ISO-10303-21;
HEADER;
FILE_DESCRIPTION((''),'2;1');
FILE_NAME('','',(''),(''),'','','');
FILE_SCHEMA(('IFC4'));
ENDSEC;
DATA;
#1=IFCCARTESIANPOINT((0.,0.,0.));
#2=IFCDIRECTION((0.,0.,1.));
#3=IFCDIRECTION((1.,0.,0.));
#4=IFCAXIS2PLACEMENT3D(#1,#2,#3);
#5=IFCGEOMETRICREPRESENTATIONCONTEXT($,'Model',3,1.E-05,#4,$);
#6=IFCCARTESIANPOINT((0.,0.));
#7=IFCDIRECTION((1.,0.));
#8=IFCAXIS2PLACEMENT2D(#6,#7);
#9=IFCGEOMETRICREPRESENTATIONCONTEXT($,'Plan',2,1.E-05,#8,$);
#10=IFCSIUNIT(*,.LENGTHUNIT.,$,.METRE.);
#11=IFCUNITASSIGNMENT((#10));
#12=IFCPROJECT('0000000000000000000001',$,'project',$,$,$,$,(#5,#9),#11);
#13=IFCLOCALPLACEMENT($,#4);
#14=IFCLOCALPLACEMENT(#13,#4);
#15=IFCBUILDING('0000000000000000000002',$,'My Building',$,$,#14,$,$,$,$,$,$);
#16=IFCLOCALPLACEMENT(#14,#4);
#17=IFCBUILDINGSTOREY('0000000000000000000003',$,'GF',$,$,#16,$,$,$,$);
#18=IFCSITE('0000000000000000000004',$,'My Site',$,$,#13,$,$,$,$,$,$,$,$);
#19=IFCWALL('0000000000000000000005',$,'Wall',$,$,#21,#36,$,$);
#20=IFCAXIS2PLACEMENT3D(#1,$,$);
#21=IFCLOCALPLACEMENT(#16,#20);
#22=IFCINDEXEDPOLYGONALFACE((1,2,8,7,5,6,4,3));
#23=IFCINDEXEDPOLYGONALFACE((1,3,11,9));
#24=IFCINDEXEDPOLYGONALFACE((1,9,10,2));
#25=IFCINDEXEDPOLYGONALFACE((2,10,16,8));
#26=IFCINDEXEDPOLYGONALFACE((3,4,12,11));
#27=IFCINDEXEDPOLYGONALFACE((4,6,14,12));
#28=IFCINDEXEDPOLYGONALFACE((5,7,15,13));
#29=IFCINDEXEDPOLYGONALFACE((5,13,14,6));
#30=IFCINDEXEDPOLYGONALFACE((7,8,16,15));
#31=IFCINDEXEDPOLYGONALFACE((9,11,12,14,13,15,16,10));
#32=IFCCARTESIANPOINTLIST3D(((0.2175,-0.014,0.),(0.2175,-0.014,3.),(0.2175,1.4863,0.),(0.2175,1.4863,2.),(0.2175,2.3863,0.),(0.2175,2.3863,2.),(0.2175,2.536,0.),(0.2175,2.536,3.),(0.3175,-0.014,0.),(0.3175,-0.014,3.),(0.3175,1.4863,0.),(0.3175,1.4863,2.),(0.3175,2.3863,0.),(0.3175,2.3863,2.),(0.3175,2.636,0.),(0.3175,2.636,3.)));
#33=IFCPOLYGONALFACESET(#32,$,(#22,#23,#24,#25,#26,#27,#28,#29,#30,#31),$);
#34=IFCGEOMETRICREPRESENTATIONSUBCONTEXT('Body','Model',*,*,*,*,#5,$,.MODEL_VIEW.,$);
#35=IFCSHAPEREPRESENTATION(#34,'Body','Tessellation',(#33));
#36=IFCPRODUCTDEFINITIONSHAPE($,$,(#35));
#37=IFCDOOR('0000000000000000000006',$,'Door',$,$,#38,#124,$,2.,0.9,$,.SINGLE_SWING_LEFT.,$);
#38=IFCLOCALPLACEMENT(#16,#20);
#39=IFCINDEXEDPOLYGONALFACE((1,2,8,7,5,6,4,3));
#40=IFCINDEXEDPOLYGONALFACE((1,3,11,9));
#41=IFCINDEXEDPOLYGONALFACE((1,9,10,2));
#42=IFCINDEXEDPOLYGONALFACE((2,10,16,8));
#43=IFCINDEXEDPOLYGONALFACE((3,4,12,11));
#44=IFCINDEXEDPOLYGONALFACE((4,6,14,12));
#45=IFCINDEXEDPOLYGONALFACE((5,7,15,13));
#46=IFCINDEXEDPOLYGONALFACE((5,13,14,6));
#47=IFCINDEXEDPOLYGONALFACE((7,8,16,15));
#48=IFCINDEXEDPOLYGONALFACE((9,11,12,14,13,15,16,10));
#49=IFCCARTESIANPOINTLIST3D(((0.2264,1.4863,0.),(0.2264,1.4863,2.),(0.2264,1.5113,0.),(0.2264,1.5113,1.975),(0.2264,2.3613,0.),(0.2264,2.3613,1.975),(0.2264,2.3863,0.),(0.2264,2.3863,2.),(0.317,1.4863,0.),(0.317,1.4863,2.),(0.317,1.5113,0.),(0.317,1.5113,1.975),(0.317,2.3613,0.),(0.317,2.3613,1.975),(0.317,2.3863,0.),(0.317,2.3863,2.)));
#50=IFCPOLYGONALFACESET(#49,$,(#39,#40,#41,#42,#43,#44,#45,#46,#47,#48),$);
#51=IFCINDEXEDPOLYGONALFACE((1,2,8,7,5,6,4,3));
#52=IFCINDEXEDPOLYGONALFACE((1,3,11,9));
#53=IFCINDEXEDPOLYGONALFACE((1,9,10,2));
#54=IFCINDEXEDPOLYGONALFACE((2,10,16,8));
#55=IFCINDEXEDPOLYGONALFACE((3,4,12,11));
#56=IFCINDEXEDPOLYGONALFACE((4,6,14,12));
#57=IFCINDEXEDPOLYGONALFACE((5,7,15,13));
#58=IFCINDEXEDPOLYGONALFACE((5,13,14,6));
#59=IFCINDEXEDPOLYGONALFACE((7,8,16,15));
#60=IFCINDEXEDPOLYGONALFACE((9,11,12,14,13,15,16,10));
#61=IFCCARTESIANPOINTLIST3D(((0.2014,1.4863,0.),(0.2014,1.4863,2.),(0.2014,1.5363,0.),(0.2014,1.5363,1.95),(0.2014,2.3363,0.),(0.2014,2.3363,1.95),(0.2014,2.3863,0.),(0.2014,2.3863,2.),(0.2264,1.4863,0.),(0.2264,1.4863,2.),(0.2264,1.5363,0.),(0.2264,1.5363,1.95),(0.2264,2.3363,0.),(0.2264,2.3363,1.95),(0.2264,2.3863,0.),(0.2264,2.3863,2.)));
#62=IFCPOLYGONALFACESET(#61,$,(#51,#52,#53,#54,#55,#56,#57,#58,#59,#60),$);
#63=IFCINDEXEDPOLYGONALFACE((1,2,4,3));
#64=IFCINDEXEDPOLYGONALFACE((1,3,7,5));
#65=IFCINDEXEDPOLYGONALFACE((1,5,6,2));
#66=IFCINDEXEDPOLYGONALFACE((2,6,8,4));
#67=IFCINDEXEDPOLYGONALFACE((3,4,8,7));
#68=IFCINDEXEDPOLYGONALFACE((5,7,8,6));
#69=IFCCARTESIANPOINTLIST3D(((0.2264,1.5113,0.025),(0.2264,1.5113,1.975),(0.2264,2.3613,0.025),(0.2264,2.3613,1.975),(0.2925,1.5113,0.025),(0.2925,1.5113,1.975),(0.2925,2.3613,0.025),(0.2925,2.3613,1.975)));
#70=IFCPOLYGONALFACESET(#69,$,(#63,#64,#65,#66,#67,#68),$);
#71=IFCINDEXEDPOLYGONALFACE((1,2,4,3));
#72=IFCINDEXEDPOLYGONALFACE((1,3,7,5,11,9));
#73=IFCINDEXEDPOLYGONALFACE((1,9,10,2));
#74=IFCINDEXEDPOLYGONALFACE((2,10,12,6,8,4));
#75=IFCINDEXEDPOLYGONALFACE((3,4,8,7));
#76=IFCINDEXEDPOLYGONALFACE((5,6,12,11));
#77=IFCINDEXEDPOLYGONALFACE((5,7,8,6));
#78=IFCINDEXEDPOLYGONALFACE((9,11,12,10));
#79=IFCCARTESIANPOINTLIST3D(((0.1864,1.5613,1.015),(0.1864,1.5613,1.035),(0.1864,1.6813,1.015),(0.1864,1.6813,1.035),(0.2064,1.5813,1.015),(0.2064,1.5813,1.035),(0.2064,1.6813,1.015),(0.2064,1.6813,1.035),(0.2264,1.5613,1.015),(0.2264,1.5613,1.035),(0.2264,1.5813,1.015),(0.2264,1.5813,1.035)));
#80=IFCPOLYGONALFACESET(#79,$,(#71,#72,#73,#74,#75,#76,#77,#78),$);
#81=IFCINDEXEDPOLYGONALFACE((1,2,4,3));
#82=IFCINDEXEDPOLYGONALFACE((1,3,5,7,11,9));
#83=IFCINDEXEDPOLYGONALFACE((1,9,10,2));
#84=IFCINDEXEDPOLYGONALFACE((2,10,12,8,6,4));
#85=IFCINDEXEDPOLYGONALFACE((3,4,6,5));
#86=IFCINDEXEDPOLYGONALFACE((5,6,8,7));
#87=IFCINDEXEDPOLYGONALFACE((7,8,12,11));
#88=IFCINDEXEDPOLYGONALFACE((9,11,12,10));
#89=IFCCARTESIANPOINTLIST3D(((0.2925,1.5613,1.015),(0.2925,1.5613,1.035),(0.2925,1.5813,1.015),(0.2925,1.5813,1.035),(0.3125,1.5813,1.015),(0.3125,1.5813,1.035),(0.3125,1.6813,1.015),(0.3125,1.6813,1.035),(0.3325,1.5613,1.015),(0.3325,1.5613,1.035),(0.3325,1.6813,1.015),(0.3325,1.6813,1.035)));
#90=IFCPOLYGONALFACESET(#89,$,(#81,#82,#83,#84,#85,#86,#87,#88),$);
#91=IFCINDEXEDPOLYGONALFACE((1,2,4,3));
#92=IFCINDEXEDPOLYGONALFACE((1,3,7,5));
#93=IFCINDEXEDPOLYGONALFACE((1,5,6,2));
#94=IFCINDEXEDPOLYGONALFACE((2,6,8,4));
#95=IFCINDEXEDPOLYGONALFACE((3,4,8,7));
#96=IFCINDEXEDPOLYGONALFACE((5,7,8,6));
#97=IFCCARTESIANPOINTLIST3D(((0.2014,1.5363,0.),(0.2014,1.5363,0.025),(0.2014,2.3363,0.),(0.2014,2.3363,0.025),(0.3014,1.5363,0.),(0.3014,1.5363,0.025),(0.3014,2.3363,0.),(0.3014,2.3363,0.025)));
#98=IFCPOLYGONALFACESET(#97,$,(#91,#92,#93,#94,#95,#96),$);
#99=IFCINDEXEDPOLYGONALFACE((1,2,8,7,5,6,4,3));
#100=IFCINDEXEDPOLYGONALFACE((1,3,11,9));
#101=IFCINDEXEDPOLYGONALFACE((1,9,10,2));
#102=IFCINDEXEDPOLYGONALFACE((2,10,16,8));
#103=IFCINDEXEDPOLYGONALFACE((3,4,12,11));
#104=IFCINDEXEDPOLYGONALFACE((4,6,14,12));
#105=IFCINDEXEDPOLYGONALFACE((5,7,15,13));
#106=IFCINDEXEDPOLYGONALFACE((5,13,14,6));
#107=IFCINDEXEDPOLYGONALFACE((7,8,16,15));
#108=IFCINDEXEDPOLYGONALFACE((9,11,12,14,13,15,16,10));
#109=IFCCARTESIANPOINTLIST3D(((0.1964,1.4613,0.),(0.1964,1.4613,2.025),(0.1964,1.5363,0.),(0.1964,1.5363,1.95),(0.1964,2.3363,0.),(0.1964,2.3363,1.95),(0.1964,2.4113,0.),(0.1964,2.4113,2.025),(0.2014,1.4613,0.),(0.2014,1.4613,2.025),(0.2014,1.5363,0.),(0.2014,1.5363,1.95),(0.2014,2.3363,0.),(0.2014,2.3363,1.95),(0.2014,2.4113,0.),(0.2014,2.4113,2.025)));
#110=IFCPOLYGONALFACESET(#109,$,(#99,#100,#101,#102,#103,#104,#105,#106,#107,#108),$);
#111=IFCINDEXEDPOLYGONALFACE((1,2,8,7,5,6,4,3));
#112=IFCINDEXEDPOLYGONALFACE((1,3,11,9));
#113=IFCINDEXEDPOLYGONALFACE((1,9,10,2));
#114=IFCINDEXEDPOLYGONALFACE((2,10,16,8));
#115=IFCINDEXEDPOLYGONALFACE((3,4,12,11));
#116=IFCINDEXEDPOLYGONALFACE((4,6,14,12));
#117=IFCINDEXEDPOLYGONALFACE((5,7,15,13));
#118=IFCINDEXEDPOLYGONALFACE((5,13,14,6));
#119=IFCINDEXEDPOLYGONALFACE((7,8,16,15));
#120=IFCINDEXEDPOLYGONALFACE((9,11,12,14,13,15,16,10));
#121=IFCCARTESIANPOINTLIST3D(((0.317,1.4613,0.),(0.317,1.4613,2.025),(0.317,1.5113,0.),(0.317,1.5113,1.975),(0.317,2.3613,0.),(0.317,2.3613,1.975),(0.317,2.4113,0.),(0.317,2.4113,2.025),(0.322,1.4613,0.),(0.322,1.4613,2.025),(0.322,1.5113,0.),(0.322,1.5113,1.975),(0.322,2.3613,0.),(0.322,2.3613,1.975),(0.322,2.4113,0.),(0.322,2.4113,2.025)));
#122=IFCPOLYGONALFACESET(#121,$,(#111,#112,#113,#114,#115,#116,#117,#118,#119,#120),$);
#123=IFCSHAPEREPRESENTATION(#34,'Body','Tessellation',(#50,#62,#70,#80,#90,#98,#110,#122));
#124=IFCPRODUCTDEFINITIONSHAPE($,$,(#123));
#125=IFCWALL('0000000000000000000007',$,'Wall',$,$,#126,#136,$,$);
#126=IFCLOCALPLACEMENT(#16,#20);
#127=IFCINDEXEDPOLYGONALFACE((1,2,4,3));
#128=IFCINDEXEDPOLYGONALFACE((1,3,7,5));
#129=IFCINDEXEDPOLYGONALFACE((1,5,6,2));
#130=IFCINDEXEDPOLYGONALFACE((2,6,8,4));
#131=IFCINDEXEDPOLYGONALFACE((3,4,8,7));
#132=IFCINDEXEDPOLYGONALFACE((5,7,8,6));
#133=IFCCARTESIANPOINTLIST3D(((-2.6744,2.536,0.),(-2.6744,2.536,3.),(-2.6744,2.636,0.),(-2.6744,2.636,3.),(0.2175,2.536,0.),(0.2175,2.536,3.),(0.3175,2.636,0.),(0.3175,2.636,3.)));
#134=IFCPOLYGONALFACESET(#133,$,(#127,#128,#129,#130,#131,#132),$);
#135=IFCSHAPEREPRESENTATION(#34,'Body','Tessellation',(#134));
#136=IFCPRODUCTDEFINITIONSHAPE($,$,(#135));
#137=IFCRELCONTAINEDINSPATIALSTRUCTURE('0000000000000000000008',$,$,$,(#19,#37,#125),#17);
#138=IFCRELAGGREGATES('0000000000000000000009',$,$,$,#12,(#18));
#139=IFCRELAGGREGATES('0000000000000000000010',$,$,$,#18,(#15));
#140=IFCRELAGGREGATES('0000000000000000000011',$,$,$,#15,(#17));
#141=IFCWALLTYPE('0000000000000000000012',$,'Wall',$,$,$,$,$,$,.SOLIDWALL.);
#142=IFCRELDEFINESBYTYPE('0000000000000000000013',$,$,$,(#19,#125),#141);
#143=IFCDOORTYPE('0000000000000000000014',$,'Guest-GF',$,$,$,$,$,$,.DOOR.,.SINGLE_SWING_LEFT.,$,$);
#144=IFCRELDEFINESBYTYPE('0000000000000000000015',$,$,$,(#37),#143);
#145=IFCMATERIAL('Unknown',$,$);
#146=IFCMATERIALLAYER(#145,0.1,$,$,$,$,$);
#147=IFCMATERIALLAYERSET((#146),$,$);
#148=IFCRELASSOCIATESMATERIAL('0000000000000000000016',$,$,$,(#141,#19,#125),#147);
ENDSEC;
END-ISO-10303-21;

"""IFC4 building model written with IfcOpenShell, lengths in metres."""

from ifc_helpers import new_model, entity, si_unit, frame, origin_with_axes, origin_2d_with_axis, place, context, subcontext, project, spatial, line, indexed_curve, outline, extrude, shape, source, transform, mapped, material, layer, layer_set, layer_usage, type_object, type_shapes, element, fill, save


model = new_model("IFC4")

# Units and contexts
model_context = context("Model", 3, precision=1e-05, world=origin_with_axes())
plan_context = context("Plan", 2, precision=1e-05, world=origin_2d_with_axis())
body_context_1 = subcontext(model_context, "Body", "Model", "MODEL_VIEW")
body_context_2 = subcontext(plan_context, "Body", "Plan", "PLAN_VIEW")
ifc_project = project(units=[si_unit("LENGTHUNIT", "METRE")], contexts=[model_context, plan_context])

# Site, building, storey
site_placement = place(None, origin_with_axes())
site = spatial("IfcSite", under=ifc_project, at=site_placement, Name="My Site")
building_placement = place(site_placement, origin_with_axes())
building = spatial("IfcBuilding", under=site, at=building_placement, Name="My Building")
storey_placement = place(building_placement, origin_with_axes())
storey = spatial("IfcBuildingStorey", under=building, at=storey_placement, Name="GF")

# Shared definitions
ifc_material_1 = material(Name="Unknown")

# Shared definitions
ifc_layer_1 = layer(ifc_material_1, 0.1)
ifc_layer_set_1 = layer_set([ifc_layer_1])
wall_type = type_object("IfcWallType", Name="Wall", PredefinedType="SOLIDWALL", material=ifc_layer_set_1)

# Wall, opening, door
ifc_layer_usage_1 = layer_usage(ifc_layer_set_1, "AXIS2", "POSITIVE", 0.0)
wall_1_placement = place(storey_placement, frame((0.3175, -0.114, 0.0), z_axis=(0.0, 0.0, 1.0), x_axis=(0.0, 1.0, 0.0)))
wall_1 = element("IfcWall", 1, at=wall_1_placement, inside=storey, type_object=wall_type, material=ifc_layer_usage_1, Name="Wall", context=body_context_1, shape_type="SweptSolid", body=[
    extrude(outline(indexed_curve([(0.1, 0.0), (0.1, 0.1), (2.65, 0.1), (2.75, 0.0)], segments=[line(1, 2, 3, 4, 1)])), origin_with_axes(), (0.0, 0.0, 1.0), 3.0),
])
shared_shape_1 = source(origin_with_axes(), body_context_1, "Body", "SweptSolid", [
    extrude(outline(indexed_curve([(0.0, 0.0), (0.9, 0.0), (0.9, 2.0), (0.0, 2.0)], segments=[line(1, 2, 3, 4, 1)])), frame((0.0, -0.6, 0.0), z_axis=(0.0, -1.0, 0.0), x_axis=(1.0, 0.0, 0.0)), (0.0, 0.0, -1.0), 1.2),
])
opening_1_placement = place(wall_1_placement, frame((2.5003, 0.1161, 0.0), z_axis=(0.0, 0.0, 1.0), x_axis=(-1.0, 0.0, 0.0)))
opening_1 = element("IfcOpeningElement", 2, at=opening_1_placement, cuts=wall_1, PredefinedType="OPENING", context=body_context_1, shape_type="MappedRepresentation", body=[
    mapped(shared_shape_1, transform((0.0, 0.0, 0.0), x_axis=(1.0, 0.0, 0.0), y_axis=(0.0, 1.0, 0.0), z_axis=(0.0, 0.0, 1.0), scale=1.0)),
])
door_type_1 = type_object("IfcDoorType", Name="Guest-GF", OperationType="SINGLE_SWING_LEFT", PredefinedType="DOOR")
shared_shape_2 = source(origin_with_axes(), body_context_1, "Body", "SweptSolid", [
    extrude(outline(indexed_curve([(0.0, 0.0), (0.0, 2.0), (0.9, 2.0), (0.9, 0.0), (0.875, 0.0), (0.875, 1.975), (0.025, 1.975), (0.025, 0.0)], segments=[line(1, 2, 3, 4, 5, 6, 7, 8, 1)])), frame((0.0, 0.025, 0.0), z_axis=(0.0, -1.0, 0.0), x_axis=(1.0, 0.0, 0.0)), (0.0, 0.0, -1.0), 0.0906),
    extrude(outline(indexed_curve([(0.0, 0.0), (0.0, 2.0), (0.9, 2.0), (0.9, 0.0), (0.85, 0.0), (0.85, 1.95), (0.05, 1.95), (0.05, 0.0)], segments=[line(1, 2, 3, 4, 5, 6, 7, 8, 1)])), frame((0.0, 0.0, 0.0), z_axis=(0.0, -1.0, 0.0), x_axis=(1.0, 0.0, 0.0)), (0.0, 0.0, -1.0), 0.025),
    extrude(outline(indexed_curve([(0.0, 0.0), (0.85, 0.0), (0.85, 0.0661), (0.0, 0.0661)], segments=[line(1, 2, 3, 4, 1)])), frame((0.025, 0.025, 0.025), z_axis=(0.0, 0.0, 1.0), x_axis=(1.0, 0.0, 0.0)), (0.0, 0.0, 1.0), 1.95),
    extrude(outline(indexed_curve([(0.0, 0.0), (0.0, -0.04), (-0.12, -0.04), (-0.12, -0.02), (-0.02, -0.02), (-0.02, 0.0)], segments=[line(1, 2, 3, 4, 5, 6, 1)])), frame((0.825, 0.025, 1.015), z_axis=(0.0, 0.0, 1.0), x_axis=(1.0, 0.0, 0.0)), (0.0, 0.0, 1.0), 0.02),
    extrude(outline(indexed_curve([(0.0, 0.0), (0.0, 0.04), (-0.12, 0.04), (-0.12, 0.02), (-0.02, 0.02), (-0.02, 0.0)], segments=[line(1, 2, 3, 4, 5, 6, 1)])), frame((0.825, 0.0911, 1.015), z_axis=(0.0, 0.0, 1.0), x_axis=(1.0, 0.0, 0.0)), (0.0, 0.0, 1.0), 0.02),
    extrude(outline(indexed_curve([(0.0, 0.0), (0.8, 0.0), (0.8, 0.1), (0.0, 0.1)], segments=[line(1, 2, 3, 4, 1)])), frame((0.05, 0.0, 0.0), z_axis=(0.0, 0.0, 1.0), x_axis=(1.0, 0.0, 0.0)), (0.0, 0.0, 1.0), 0.025),
    extrude(outline(indexed_curve([(0.0, 0.0), (0.0, 2.025), (0.95, 2.025), (0.95, 0.0), (0.875, 0.0), (0.875, 1.95), (0.075, 1.95), (0.075, 0.0)], segments=[line(1, 2, 3, 4, 5, 6, 7, 8, 1)])), frame((-0.025, -0.005, 0.0), z_axis=(0.0, -1.0, 0.0), x_axis=(1.0, 0.0, 0.0)), (0.0, 0.0, -1.0), 0.005),
    extrude(outline(indexed_curve([(0.0, 0.0), (0.0, 2.025), (0.95, 2.025), (0.95, 0.0), (0.9, 0.0), (0.9, 1.975), (0.05, 1.975), (0.05, 0.0)], segments=[line(1, 2, 3, 4, 5, 6, 7, 8, 1)])), frame((-0.025, 0.1156, 0.0), z_axis=(0.0, -1.0, 0.0), x_axis=(1.0, 0.0, 0.0)), (0.0, 0.0, -1.0), 0.005),
])
shared_shape_3 = source(origin_with_axes(), body_context_2, "Body", "Curve2D", [
    entity("IfcIndexedPolyCurve", entity("IfcCartesianPointList2D", [[0.0, 0.0], [0.0, 0.1156], [0.025, 0.1156], [0.025, 0.025], [0.05, 0.025], [0.05, 0.0]]), [entity("IfcLineIndex", [1, 2, 3, 4, 5, 6, 1])]),
    entity("IfcIndexedPolyCurve", entity("IfcCartesianPointList2D", [[0.9, 0.0], [0.9, 0.1156], [0.875, 0.1156], [0.875, 0.025], [0.85, 0.025], [0.85, 0.0]]), [entity("IfcLineIndex", [1, 2, 3, 4, 5, 6, 1])]),
    entity("IfcTrimmedCurve", entity("IfcEllipse", entity("IfcAxis2Placement2D", entity("IfcCartesianPoint", [0.0911, 0.1156]), entity("IfcDirection", [1.0, 0.0])), 0.7839, 0.85), [entity("IfcCartesianPoint", [0.875, 0.1156])], [entity("IfcCartesianPoint", [0.0911, 0.9656])], True, "CARTESIAN"),
    entity("IfcIndexedPolyCurve", entity("IfcCartesianPointList2D", [[0.025, 0.1156], [0.0911, 0.1156], [0.0911, 0.9656], [0.025, 0.9656]]), [entity("IfcLineIndex", [1, 2, 3, 4, 1])]),
])
type_shapes(door_type_1, [shared_shape_2, shared_shape_3])
door_1_placement = place(opening_1_placement, frame((0.0, 0.0, 0.0), z_axis=(0.0, 0.0, 1.0), x_axis=(1.0, 0.0, 0.0)))
door_1 = element("IfcDoor", 3, at=door_1_placement, inside=storey, type_object=door_type_1, Name="Door", OperationType="SINGLE_SWING_LEFT", OverallHeight=2.0, OverallWidth=0.9, shapes=[
    shape(body_context_1, "Body", "MappedRepresentation", [mapped(shared_shape_2, transform((0.0, 0.0, 0.0), x_axis=(1.0, 0.0, 0.0), y_axis=(0.0, 1.0, 0.0), z_axis=(0.0, 0.0, 1.0), scale=1.0))]),
    shape(body_context_2, "Body", "MappedRepresentation", [mapped(shared_shape_3, transform((0.0, 0.0, 0.0), x_axis=(1.0, 0.0, 0.0), y_axis=(0.0, 1.0, 0.0), z_axis=(0.0, 0.0, 1.0), scale=1.0))]),
])
fill(opening_1, door_1)

# Wall
ifc_layer_usage_2 = layer_usage(ifc_layer_set_1, "AXIS2", "POSITIVE", 0.0)
wall_2_placement = place(storey_placement, frame((0.3175, 2.636, 0.0), z_axis=(0.0, 0.0, 1.0), x_axis=(-1.0, 0.0, 0.0)))
element("IfcWall", 4, at=wall_2_placement, inside=storey, type_object=wall_type, material=ifc_layer_usage_2, Name="Wall", context=body_context_1, shape_type="SweptSolid", body=[
    extrude(outline(indexed_curve([(0.0, 0.0), (0.1, 0.1), (2.9919, 0.1), (2.9919, 0.0)], segments=[line(1, 2, 3, 4, 1)])), origin_with_axes(), (0.0, 0.0, 1.0), 3.0),
])

save(model, "model.ifc")
